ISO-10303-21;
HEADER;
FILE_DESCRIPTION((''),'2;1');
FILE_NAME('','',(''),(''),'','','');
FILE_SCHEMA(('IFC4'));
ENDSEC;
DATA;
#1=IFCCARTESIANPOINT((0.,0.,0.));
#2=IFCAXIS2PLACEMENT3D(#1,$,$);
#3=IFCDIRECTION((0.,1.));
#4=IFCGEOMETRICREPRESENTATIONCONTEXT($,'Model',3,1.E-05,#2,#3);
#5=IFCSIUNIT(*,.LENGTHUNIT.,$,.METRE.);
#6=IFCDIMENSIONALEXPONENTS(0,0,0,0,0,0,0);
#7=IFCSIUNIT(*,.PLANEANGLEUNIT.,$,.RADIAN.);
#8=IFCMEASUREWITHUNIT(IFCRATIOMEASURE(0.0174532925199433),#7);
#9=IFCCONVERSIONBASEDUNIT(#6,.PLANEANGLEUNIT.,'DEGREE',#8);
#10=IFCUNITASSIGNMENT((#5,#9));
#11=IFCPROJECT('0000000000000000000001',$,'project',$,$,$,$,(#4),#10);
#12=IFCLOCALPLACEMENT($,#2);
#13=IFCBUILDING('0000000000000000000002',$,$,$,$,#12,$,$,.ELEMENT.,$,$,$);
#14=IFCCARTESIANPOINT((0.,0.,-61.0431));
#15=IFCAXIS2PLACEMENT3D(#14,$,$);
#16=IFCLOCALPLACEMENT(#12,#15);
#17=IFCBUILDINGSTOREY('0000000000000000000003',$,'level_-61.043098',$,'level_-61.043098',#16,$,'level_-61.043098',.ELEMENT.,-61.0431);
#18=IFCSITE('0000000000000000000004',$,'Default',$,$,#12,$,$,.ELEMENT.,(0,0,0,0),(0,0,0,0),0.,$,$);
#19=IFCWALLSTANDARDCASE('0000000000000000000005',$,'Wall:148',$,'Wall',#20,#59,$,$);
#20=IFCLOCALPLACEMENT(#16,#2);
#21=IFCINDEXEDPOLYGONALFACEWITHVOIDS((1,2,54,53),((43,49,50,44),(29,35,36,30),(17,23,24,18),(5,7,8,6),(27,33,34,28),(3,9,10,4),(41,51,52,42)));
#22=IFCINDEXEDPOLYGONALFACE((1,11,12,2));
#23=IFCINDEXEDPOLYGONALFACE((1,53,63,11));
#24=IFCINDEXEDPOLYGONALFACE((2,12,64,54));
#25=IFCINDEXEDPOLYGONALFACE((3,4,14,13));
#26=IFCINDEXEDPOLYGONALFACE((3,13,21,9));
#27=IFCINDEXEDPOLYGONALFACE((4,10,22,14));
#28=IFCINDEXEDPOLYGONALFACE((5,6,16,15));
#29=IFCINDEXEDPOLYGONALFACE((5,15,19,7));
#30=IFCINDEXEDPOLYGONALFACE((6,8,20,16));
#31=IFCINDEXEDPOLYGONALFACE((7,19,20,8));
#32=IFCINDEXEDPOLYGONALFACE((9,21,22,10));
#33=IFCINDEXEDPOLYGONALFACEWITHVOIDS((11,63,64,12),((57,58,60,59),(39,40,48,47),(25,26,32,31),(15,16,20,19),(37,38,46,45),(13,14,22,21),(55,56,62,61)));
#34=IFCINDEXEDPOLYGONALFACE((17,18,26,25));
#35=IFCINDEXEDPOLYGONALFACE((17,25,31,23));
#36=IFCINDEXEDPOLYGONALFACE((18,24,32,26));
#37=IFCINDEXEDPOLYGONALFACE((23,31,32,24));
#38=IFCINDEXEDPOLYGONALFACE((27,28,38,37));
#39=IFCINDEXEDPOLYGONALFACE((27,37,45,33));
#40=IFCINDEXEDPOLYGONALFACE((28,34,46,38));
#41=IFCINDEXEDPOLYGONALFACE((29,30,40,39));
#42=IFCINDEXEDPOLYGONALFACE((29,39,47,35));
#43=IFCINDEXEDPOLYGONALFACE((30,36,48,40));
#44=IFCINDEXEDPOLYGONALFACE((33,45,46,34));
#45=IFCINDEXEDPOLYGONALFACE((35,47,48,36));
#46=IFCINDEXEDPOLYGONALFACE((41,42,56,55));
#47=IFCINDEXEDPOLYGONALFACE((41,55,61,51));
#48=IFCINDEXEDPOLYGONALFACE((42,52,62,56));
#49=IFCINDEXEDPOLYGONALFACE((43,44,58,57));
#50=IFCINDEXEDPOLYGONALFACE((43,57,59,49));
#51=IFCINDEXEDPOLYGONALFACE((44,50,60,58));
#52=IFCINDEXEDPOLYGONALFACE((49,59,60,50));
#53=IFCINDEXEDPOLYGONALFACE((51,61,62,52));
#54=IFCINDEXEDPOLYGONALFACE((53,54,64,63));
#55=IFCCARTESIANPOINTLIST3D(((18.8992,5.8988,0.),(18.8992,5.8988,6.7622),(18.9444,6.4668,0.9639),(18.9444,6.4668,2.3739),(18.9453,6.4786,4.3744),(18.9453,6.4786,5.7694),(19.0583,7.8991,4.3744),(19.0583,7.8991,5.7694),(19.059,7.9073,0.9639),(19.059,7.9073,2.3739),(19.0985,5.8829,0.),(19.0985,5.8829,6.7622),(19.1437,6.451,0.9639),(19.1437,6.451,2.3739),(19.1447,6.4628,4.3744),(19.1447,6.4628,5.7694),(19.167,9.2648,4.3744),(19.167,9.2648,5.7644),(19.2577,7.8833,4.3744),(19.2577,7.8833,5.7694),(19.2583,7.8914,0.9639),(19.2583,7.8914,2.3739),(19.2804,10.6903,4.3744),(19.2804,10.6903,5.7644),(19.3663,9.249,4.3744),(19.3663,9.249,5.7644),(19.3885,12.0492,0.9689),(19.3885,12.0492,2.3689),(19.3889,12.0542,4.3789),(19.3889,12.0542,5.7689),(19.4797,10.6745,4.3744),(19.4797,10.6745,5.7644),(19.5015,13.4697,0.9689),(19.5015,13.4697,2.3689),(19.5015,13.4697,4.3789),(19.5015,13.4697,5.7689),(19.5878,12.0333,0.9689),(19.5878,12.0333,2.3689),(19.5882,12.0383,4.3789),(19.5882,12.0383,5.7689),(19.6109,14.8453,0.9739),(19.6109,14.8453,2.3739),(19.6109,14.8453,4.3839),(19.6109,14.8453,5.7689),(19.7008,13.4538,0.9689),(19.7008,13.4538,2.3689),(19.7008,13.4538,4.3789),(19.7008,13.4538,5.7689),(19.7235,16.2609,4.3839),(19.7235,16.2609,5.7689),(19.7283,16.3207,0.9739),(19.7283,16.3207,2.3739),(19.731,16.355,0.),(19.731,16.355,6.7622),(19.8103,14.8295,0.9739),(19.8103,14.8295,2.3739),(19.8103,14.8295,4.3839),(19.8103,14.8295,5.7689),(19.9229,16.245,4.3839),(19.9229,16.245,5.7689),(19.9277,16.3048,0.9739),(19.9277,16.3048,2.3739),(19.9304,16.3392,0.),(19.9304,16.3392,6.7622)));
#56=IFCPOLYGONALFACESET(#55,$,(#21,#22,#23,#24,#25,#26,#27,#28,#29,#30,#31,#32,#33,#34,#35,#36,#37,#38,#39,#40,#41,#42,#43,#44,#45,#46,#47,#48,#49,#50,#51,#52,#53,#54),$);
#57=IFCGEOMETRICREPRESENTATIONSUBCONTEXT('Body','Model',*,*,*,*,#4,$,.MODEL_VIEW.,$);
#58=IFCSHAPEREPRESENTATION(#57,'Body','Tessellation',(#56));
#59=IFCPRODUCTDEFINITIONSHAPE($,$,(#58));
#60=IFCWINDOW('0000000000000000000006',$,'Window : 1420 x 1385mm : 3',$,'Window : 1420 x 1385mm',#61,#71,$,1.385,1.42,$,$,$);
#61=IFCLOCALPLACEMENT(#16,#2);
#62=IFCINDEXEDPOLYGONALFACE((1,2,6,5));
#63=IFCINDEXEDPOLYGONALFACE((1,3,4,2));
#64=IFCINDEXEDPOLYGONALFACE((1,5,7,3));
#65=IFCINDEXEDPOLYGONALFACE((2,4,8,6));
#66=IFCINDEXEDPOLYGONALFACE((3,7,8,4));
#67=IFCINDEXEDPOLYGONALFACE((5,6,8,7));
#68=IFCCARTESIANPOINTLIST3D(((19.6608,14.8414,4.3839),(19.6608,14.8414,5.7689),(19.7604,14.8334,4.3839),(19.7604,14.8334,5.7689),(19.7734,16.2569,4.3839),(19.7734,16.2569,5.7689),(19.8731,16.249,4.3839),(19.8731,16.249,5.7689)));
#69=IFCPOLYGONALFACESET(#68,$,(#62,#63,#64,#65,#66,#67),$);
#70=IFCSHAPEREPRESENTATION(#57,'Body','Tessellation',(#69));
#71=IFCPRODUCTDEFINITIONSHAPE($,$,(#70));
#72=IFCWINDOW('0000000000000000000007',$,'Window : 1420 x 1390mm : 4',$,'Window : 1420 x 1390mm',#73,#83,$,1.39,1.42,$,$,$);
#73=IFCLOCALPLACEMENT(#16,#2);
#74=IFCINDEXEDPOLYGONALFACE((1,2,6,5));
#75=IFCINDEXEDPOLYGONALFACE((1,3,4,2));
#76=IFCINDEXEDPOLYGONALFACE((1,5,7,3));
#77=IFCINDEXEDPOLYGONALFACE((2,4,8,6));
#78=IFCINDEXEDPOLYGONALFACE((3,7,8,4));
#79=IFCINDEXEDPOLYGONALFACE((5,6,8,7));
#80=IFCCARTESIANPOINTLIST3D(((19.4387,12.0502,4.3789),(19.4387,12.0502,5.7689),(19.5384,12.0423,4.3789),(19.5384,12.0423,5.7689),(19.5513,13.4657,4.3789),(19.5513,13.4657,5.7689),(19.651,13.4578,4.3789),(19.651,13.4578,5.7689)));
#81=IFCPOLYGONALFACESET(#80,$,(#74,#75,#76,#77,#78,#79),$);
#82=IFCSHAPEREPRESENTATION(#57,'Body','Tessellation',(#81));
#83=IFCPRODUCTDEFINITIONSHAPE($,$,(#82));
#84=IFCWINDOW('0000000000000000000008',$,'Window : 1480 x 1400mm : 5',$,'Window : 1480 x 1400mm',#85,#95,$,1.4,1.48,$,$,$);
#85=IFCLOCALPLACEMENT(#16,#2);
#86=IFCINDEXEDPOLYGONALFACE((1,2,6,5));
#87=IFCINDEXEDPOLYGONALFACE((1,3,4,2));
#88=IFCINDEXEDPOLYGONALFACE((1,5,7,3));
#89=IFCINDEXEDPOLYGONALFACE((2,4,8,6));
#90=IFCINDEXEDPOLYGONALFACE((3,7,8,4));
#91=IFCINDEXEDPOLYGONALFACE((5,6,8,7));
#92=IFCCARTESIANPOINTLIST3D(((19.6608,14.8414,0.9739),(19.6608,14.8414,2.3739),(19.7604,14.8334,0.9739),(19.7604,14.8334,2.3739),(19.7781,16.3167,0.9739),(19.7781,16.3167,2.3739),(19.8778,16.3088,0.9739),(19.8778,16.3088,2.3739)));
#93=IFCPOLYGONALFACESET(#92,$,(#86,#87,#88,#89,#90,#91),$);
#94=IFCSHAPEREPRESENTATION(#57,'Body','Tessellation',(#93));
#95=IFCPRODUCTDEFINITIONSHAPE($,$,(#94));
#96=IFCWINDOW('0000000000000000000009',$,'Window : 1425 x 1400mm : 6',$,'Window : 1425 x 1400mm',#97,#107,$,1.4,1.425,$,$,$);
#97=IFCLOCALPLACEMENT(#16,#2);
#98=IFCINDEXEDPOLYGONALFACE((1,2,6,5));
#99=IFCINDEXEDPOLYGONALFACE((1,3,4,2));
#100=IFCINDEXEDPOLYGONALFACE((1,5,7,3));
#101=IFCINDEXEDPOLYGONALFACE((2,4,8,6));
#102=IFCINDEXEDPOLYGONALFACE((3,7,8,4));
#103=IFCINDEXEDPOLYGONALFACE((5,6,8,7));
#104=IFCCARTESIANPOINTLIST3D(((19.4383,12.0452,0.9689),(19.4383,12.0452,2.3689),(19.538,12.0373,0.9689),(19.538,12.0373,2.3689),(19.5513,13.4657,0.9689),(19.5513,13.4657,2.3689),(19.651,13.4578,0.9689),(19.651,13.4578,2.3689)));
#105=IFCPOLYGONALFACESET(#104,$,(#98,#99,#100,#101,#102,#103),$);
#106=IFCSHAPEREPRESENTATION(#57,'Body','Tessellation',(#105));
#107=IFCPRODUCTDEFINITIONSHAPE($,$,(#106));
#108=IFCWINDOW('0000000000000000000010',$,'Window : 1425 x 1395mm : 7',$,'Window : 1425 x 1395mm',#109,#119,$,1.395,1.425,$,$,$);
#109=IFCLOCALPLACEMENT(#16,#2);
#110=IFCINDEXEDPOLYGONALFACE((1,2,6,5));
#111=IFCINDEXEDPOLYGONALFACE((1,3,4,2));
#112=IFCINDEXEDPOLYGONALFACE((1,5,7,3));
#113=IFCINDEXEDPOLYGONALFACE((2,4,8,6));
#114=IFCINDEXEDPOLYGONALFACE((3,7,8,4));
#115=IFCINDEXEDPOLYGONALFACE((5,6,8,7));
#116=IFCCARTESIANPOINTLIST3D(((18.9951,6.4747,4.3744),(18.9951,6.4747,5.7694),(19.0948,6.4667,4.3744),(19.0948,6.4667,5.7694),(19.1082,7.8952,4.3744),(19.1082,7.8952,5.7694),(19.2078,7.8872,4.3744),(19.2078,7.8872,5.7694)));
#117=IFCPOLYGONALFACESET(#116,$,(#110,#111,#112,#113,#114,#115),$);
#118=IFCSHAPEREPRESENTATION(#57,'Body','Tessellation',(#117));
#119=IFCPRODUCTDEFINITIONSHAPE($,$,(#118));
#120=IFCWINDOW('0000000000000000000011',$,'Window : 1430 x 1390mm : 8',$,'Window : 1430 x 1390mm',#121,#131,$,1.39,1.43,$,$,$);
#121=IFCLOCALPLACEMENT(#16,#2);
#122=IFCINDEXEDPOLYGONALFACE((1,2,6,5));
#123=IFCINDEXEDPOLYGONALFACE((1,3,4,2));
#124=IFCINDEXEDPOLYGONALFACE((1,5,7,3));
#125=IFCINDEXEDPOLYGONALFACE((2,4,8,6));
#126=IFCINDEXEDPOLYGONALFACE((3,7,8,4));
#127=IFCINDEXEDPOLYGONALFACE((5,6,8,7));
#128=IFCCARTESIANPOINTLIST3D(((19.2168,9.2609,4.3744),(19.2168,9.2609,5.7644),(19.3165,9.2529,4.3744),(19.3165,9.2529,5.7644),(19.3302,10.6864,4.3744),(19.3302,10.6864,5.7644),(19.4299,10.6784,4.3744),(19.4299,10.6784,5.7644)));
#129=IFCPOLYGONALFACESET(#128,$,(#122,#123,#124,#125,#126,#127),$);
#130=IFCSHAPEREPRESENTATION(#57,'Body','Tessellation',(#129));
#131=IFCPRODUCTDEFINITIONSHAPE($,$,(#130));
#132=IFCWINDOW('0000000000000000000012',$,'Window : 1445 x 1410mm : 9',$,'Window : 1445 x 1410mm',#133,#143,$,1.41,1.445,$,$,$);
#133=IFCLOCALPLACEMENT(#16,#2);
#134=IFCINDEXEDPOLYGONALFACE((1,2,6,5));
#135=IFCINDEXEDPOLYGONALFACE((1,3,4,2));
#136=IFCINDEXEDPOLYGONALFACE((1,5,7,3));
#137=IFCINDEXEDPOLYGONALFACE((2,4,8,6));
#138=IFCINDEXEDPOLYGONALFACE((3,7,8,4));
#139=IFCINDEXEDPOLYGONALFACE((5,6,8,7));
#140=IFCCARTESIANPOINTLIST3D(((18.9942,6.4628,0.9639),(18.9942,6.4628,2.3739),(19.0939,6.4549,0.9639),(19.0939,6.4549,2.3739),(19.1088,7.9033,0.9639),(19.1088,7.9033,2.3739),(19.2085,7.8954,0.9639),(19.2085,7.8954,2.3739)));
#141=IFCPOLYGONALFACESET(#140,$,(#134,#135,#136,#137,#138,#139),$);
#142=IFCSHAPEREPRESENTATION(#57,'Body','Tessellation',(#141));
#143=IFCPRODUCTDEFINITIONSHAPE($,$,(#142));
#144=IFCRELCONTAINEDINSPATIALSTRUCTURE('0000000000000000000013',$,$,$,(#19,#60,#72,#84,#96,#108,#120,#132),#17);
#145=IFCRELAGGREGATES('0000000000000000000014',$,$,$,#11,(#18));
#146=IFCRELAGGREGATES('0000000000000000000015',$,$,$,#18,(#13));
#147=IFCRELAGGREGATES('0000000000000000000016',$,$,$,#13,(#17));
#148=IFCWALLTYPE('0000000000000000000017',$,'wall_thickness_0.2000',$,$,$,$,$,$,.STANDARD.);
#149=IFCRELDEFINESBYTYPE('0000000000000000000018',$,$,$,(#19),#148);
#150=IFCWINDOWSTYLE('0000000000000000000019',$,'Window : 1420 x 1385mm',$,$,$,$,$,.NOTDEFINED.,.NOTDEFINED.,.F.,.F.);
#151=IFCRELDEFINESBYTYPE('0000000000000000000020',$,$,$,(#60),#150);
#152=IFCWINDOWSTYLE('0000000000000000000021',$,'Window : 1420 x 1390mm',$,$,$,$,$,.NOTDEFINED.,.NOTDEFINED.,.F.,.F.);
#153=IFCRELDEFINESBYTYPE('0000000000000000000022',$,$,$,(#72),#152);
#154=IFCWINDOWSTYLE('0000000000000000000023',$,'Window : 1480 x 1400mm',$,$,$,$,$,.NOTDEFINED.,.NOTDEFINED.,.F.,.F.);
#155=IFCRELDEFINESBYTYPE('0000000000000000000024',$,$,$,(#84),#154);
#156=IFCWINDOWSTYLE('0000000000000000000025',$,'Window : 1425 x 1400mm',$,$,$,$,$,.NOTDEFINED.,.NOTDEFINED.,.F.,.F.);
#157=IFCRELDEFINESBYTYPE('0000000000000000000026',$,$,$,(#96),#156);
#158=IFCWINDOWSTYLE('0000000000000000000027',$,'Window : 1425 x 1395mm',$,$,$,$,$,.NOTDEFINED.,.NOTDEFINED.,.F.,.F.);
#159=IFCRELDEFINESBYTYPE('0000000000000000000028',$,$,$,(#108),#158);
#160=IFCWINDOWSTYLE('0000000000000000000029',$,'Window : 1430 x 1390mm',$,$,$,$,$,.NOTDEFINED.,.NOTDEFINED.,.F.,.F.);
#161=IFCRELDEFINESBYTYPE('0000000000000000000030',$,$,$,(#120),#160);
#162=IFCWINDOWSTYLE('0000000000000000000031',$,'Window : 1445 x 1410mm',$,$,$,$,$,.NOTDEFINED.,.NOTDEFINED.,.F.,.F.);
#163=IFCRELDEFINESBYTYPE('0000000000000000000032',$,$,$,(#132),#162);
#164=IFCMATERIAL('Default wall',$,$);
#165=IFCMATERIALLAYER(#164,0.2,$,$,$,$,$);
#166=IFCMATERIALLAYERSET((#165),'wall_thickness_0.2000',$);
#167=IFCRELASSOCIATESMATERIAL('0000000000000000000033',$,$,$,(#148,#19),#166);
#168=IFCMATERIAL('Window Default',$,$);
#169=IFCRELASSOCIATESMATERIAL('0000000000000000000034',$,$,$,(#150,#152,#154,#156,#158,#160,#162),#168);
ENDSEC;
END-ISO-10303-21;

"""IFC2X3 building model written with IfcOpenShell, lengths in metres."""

from ifc_helpers import new_model, entity, si_unit, converted_unit, direction, frame, frame_2d, origin, origin_2d_with_axis, place, context, subcontext, project, spatial, polyline, rectangle, outline, extrude, source, transform, mapped, material, layer, layer_set, layer_usage, type_object, type_shapes, element, fill, save


model = new_model("IFC2X3")

# Units and contexts
model_context = context("Model", 3, precision=1e-05, world=origin(), true_north=direction((0.0, 1.0)))
body_context = subcontext(model_context, "Body", "Model", "MODEL_VIEW")
ifc_project = project(units=[si_unit("LENGTHUNIT", "METRE"), converted_unit("PLANEANGLEUNIT", "DEGREE", entity("IfcRatioMeasure", 0.0174532925199433), si_unit("PLANEANGLEUNIT", "RADIAN"), dimensions=[0, 0, 0, 0, 0, 0, 0])], contexts=[model_context])

# Site, building, storey
placement_1 = place(None, origin())
site = spatial("IfcSite", under=ifc_project, at=placement_1, Name="Default", CompositionType="ELEMENT", RefLatitude=(0, 0, 0, 0), RefLongitude=(0, 0, 0, 0), RefElevation=0.0)
building = spatial("IfcBuilding", under=site, at=placement_1, CompositionType="ELEMENT")
storey_placement = place(placement_1, frame((0.0, 0.0, -61.0431)))
storey = spatial("IfcBuildingStorey", under=building, at=storey_placement, Name="level_-61.043098", ObjectType="level_-61.043098", LongName="level_-61.043098", CompositionType="ELEMENT", Elevation=-61.0431)

# Wall, openings, windows
ifc_material_1 = material(Name="Default wall")
ifc_layer = layer(ifc_material_1, 0.2)
ifc_layer_set = layer_set([ifc_layer], Name="wall_thickness_0.2000")
ifc_layer_usage = layer_usage(ifc_layer_set, "AXIS2", "POSITIVE", -0.1)
wall_type = type_object("IfcWallType", Name="wall_thickness_0.2000", PredefinedType="STANDARD", material=ifc_layer_set)
wall_1_placement = place(storey_placement, frame((19.8307, 16.3471, 0.0), z_axis=(0.0, 0.0, 1.0), x_axis=(-0.079305, -0.99685, 0.0)))
wall_1 = element("IfcWallStandardCase", 1, at=wall_1_placement, inside=storey, type_object=wall_type, material=ifc_layer_usage, Name="Wall:148", ObjectType="Wall", context=body_context, shape_type="SweptSolid", body=[
    extrude(outline(polyline([(10.4893, -0.1), (10.4893, 0.1), (0.0, 0.1), (0.0, -0.1), (10.4893, -0.1)])), origin(), (0.0, 0.0, 1.0), 6.7622),
])
opening_1_placement = place(wall_1_placement, frame((0.0945, -0.1, 4.3839)))
opening_1 = element("IfcOpeningElement", 2, at=opening_1_placement, cuts=wall_1, ObjectType="Opening", context=body_context, shape_type="SweptSolid", body=[
    extrude(rectangle(XDim=1.42, YDim=1.385, at=frame_2d((0.6925, 0.71), x_axis=(0.0, 1.0))), frame((0.0, 0.0, 0.0), z_axis=(0.0, 1.0, 0.0), x_axis=(0.0, 0.0, 1.0)), (0.0, 0.0, 1.0), 0.2),
])
opening_2_placement = place(wall_1_placement, frame((2.8945, -0.1, 4.3789)))
opening_2 = element("IfcOpeningElement", 3, at=opening_2_placement, cuts=wall_1, ObjectType="Opening", context=body_context, shape_type="SweptSolid", body=[
    extrude(rectangle(XDim=1.42, YDim=1.39, at=frame_2d((0.695, 0.71), x_axis=(0.0, 1.0))), frame((0.0, 0.0, 0.0), z_axis=(0.0, 1.0, 0.0), x_axis=(0.0, 0.0, 1.0)), (0.0, 0.0, 1.0), 0.2),
])
opening_3_placement = place(wall_1_placement, frame((0.0345, -0.1, 0.9739)))
opening_3 = element("IfcOpeningElement", 4, at=opening_3_placement, cuts=wall_1, ObjectType="Opening", context=body_context, shape_type="SweptSolid", body=[
    extrude(rectangle(XDim=1.48, YDim=1.4, at=frame_2d((0.7, 0.74), x_axis=(0.0, 1.0))), frame((0.0, 0.0, 0.0), z_axis=(0.0, 1.0, 0.0), x_axis=(0.0, 0.0, 1.0)), (0.0, 0.0, 1.0), 0.2),
])
opening_4_placement = place(wall_1_placement, frame((2.8945, -0.1, 0.9689)))
opening_4 = element("IfcOpeningElement", 5, at=opening_4_placement, cuts=wall_1, ObjectType="Opening", context=body_context, shape_type="SweptSolid", body=[
    extrude(rectangle(XDim=1.425, YDim=1.4, at=frame_2d((0.7, 0.7125), x_axis=(0.0, 1.0))), frame((0.0, 0.0, 0.0), z_axis=(0.0, 1.0, 0.0), x_axis=(0.0, 0.0, 1.0)), (0.0, 0.0, 1.0), 0.2),
])
opening_5_placement = place(wall_1_placement, frame((8.4826, -0.1, 4.3744)))
opening_5 = element("IfcOpeningElement", 6, at=opening_5_placement, cuts=wall_1, ObjectType="Opening", context=body_context, shape_type="SweptSolid", body=[
    extrude(rectangle(XDim=1.425, YDim=1.395, at=frame_2d((0.6975, 0.7125), x_axis=(0.0, 1.0))), frame((0.0, 0.0, 0.0), z_axis=(0.0, 1.0, 0.0), x_axis=(0.0, 0.0, 1.0)), (0.0, 0.0, 1.0), 0.2),
])
opening_6_placement = place(wall_1_placement, frame((5.6826, -0.1, 4.3744)))
opening_6 = element("IfcOpeningElement", 7, at=opening_6_placement, cuts=wall_1, ObjectType="Opening", context=body_context, shape_type="SweptSolid", body=[
    extrude(rectangle(XDim=1.43, YDim=1.39, at=frame_2d((0.695, 0.715), x_axis=(0.0, 1.0))), frame((0.0, 0.0, 0.0), z_axis=(0.0, 1.0, 0.0), x_axis=(0.0, 0.0, 1.0)), (0.0, 0.0, 1.0), 0.2),
])
opening_7_placement = place(wall_1_placement, frame((8.4745, -0.1, 0.9639)))
opening_7 = element("IfcOpeningElement", 8, at=opening_7_placement, cuts=wall_1, ObjectType="Opening", context=body_context, shape_type="SweptSolid", body=[
    extrude(rectangle(XDim=1.445, YDim=1.41, at=frame_2d((0.705, 0.7225), x_axis=(0.0, 1.0))), frame((0.0, 0.0, 0.0), z_axis=(0.0, 1.0, 0.0), x_axis=(0.0, 0.0, 1.0)), (0.0, 0.0, 1.0), 0.2),
])
ifc_material_2 = material(Name="Window Default")
window_style_1 = type_object("IfcWindowStyle", Name="Window : 1420 x 1385mm", ConstructionType="NOTDEFINED", OperationType="NOTDEFINED", ParameterTakesPrecedence=False, Sizeable=False, material=ifc_material_2)
shared_shape_1 = source(origin(), body_context, "Body", "SweptSolid", [
    extrude(rectangle(XDim=0.1, YDim=1.42, at=origin_2d_with_axis()), frame((0.71, 0.1, 0.0), z_axis=(0.0, 0.0, 1.0), x_axis=(0.0, 1.0, 0.0)), (0.0, 0.0, 1.0), 1.385),
])
type_shapes(window_style_1, [shared_shape_1])
window_1_placement = place(opening_1_placement, origin())
window_1 = element("IfcWindow", 9, at=window_1_placement, inside=storey, type_object=window_style_1, Name="Window : 1420 x 1385mm : 3", ObjectType="Window : 1420 x 1385mm", OverallHeight=1.385, OverallWidth=1.42, context=body_context, shape_type="MappedRepresentation", body=[
    mapped(shared_shape_1, transform((0.0, 0.0, 0.0), scale=1.0)),
])
fill(opening_1, window_1)
window_style_2 = type_object("IfcWindowStyle", Name="Window : 1420 x 1390mm", ConstructionType="NOTDEFINED", OperationType="NOTDEFINED", ParameterTakesPrecedence=False, Sizeable=False, material=ifc_material_2)
shared_shape_2 = source(origin(), body_context, "Body", "SweptSolid", [
    extrude(rectangle(XDim=0.1, YDim=1.42, at=origin_2d_with_axis()), frame((0.71, 0.1, 0.0), z_axis=(0.0, 0.0, 1.0), x_axis=(0.0, 1.0, 0.0)), (0.0, 0.0, 1.0), 1.39),
])
type_shapes(window_style_2, [shared_shape_2])
window_2_placement = place(opening_2_placement, origin())
window_2 = element("IfcWindow", 10, at=window_2_placement, inside=storey, type_object=window_style_2, Name="Window : 1420 x 1390mm : 4", ObjectType="Window : 1420 x 1390mm", OverallHeight=1.39, OverallWidth=1.42, context=body_context, shape_type="MappedRepresentation", body=[
    mapped(shared_shape_2, transform((0.0, 0.0, 0.0), scale=1.0)),
])
fill(opening_2, window_2)
window_style_3 = type_object("IfcWindowStyle", Name="Window : 1480 x 1400mm", ConstructionType="NOTDEFINED", OperationType="NOTDEFINED", ParameterTakesPrecedence=False, Sizeable=False, material=ifc_material_2)
shared_shape_3 = source(origin(), body_context, "Body", "SweptSolid", [
    extrude(rectangle(XDim=0.1, YDim=1.48, at=origin_2d_with_axis()), frame((0.74, 0.1, 0.0), z_axis=(0.0, 0.0, 1.0), x_axis=(0.0, 1.0, 0.0)), (0.0, 0.0, 1.0), 1.4),
])
type_shapes(window_style_3, [shared_shape_3])
window_3_placement = place(opening_3_placement, origin())
window_3 = element("IfcWindow", 11, at=window_3_placement, inside=storey, type_object=window_style_3, Name="Window : 1480 x 1400mm : 5", ObjectType="Window : 1480 x 1400mm", OverallHeight=1.4, OverallWidth=1.48, context=body_context, shape_type="MappedRepresentation", body=[
    mapped(shared_shape_3, transform((0.0, 0.0, 0.0), scale=1.0)),
])
fill(opening_3, window_3)
window_style_4 = type_object("IfcWindowStyle", Name="Window : 1425 x 1400mm", ConstructionType="NOTDEFINED", OperationType="NOTDEFINED", ParameterTakesPrecedence=False, Sizeable=False, material=ifc_material_2)
shared_shape_4 = source(origin(), body_context, "Body", "SweptSolid", [
    extrude(rectangle(XDim=0.1, YDim=1.425, at=origin_2d_with_axis()), frame((0.7125, 0.1, 0.0), z_axis=(0.0, 0.0, 1.0), x_axis=(0.0, 1.0, 0.0)), (0.0, 0.0, 1.0), 1.4),
])
type_shapes(window_style_4, [shared_shape_4])
window_4_placement = place(opening_4_placement, origin())
window_4 = element("IfcWindow", 12, at=window_4_placement, inside=storey, type_object=window_style_4, Name="Window : 1425 x 1400mm : 6", ObjectType="Window : 1425 x 1400mm", OverallHeight=1.4, OverallWidth=1.425, context=body_context, shape_type="MappedRepresentation", body=[
    mapped(shared_shape_4, transform((0.0, 0.0, 0.0), scale=1.0)),
])
fill(opening_4, window_4)
window_style_5 = type_object("IfcWindowStyle", Name="Window : 1425 x 1395mm", ConstructionType="NOTDEFINED", OperationType="NOTDEFINED", ParameterTakesPrecedence=False, Sizeable=False, material=ifc_material_2)
shared_shape_5 = source(origin(), body_context, "Body", "SweptSolid", [
    extrude(rectangle(XDim=0.1, YDim=1.425, at=origin_2d_with_axis()), frame((0.7125, 0.1, 0.0), z_axis=(0.0, 0.0, 1.0), x_axis=(0.0, 1.0, 0.0)), (0.0, 0.0, 1.0), 1.395),
])
type_shapes(window_style_5, [shared_shape_5])
window_5_placement = place(opening_5_placement, origin())
window_5 = element("IfcWindow", 13, at=window_5_placement, inside=storey, type_object=window_style_5, Name="Window : 1425 x 1395mm : 7", ObjectType="Window : 1425 x 1395mm", OverallHeight=1.395, OverallWidth=1.425, context=body_context, shape_type="MappedRepresentation", body=[
    mapped(shared_shape_5, transform((0.0, 0.0, 0.0), scale=1.0)),
])
fill(opening_5, window_5)
window_style_6 = type_object("IfcWindowStyle", Name="Window : 1430 x 1390mm", ConstructionType="NOTDEFINED", OperationType="NOTDEFINED", ParameterTakesPrecedence=False, Sizeable=False, material=ifc_material_2)
shared_shape_6 = source(origin(), body_context, "Body", "SweptSolid", [
    extrude(rectangle(XDim=0.1, YDim=1.43, at=origin_2d_with_axis()), frame((0.715, 0.1, 0.0), z_axis=(0.0, 0.0, 1.0), x_axis=(0.0, 1.0, 0.0)), (0.0, 0.0, 1.0), 1.39),
])
type_shapes(window_style_6, [shared_shape_6])
window_6_placement = place(opening_6_placement, origin())
window_6 = element("IfcWindow", 14, at=window_6_placement, inside=storey, type_object=window_style_6, Name="Window : 1430 x 1390mm : 8", ObjectType="Window : 1430 x 1390mm", OverallHeight=1.39, OverallWidth=1.43, context=body_context, shape_type="MappedRepresentation", body=[
    mapped(shared_shape_6, transform((0.0, 0.0, 0.0), scale=1.0)),
])
fill(opening_6, window_6)
window_style_7 = type_object("IfcWindowStyle", Name="Window : 1445 x 1410mm", ConstructionType="NOTDEFINED", OperationType="NOTDEFINED", ParameterTakesPrecedence=False, Sizeable=False, material=ifc_material_2)
shared_shape_7 = source(origin(), body_context, "Body", "SweptSolid", [
    extrude(rectangle(XDim=0.1, YDim=1.445, at=origin_2d_with_axis()), frame((0.7225, 0.1, 0.0), z_axis=(0.0, 0.0, 1.0), x_axis=(0.0, 1.0, 0.0)), (0.0, 0.0, 1.0), 1.41),
])
type_shapes(window_style_7, [shared_shape_7])
window_7_placement = place(opening_7_placement, origin())
window_7 = element("IfcWindow", 15, at=window_7_placement, inside=storey, type_object=window_style_7, Name="Window : 1445 x 1410mm : 9", ObjectType="Window : 1445 x 1410mm", OverallHeight=1.41, OverallWidth=1.445, context=body_context, shape_type="MappedRepresentation", body=[
    mapped(shared_shape_7, transform((0.0, 0.0, 0.0), scale=1.0)),
])
fill(opening_7, window_7)

save(model, "model.ifc")
